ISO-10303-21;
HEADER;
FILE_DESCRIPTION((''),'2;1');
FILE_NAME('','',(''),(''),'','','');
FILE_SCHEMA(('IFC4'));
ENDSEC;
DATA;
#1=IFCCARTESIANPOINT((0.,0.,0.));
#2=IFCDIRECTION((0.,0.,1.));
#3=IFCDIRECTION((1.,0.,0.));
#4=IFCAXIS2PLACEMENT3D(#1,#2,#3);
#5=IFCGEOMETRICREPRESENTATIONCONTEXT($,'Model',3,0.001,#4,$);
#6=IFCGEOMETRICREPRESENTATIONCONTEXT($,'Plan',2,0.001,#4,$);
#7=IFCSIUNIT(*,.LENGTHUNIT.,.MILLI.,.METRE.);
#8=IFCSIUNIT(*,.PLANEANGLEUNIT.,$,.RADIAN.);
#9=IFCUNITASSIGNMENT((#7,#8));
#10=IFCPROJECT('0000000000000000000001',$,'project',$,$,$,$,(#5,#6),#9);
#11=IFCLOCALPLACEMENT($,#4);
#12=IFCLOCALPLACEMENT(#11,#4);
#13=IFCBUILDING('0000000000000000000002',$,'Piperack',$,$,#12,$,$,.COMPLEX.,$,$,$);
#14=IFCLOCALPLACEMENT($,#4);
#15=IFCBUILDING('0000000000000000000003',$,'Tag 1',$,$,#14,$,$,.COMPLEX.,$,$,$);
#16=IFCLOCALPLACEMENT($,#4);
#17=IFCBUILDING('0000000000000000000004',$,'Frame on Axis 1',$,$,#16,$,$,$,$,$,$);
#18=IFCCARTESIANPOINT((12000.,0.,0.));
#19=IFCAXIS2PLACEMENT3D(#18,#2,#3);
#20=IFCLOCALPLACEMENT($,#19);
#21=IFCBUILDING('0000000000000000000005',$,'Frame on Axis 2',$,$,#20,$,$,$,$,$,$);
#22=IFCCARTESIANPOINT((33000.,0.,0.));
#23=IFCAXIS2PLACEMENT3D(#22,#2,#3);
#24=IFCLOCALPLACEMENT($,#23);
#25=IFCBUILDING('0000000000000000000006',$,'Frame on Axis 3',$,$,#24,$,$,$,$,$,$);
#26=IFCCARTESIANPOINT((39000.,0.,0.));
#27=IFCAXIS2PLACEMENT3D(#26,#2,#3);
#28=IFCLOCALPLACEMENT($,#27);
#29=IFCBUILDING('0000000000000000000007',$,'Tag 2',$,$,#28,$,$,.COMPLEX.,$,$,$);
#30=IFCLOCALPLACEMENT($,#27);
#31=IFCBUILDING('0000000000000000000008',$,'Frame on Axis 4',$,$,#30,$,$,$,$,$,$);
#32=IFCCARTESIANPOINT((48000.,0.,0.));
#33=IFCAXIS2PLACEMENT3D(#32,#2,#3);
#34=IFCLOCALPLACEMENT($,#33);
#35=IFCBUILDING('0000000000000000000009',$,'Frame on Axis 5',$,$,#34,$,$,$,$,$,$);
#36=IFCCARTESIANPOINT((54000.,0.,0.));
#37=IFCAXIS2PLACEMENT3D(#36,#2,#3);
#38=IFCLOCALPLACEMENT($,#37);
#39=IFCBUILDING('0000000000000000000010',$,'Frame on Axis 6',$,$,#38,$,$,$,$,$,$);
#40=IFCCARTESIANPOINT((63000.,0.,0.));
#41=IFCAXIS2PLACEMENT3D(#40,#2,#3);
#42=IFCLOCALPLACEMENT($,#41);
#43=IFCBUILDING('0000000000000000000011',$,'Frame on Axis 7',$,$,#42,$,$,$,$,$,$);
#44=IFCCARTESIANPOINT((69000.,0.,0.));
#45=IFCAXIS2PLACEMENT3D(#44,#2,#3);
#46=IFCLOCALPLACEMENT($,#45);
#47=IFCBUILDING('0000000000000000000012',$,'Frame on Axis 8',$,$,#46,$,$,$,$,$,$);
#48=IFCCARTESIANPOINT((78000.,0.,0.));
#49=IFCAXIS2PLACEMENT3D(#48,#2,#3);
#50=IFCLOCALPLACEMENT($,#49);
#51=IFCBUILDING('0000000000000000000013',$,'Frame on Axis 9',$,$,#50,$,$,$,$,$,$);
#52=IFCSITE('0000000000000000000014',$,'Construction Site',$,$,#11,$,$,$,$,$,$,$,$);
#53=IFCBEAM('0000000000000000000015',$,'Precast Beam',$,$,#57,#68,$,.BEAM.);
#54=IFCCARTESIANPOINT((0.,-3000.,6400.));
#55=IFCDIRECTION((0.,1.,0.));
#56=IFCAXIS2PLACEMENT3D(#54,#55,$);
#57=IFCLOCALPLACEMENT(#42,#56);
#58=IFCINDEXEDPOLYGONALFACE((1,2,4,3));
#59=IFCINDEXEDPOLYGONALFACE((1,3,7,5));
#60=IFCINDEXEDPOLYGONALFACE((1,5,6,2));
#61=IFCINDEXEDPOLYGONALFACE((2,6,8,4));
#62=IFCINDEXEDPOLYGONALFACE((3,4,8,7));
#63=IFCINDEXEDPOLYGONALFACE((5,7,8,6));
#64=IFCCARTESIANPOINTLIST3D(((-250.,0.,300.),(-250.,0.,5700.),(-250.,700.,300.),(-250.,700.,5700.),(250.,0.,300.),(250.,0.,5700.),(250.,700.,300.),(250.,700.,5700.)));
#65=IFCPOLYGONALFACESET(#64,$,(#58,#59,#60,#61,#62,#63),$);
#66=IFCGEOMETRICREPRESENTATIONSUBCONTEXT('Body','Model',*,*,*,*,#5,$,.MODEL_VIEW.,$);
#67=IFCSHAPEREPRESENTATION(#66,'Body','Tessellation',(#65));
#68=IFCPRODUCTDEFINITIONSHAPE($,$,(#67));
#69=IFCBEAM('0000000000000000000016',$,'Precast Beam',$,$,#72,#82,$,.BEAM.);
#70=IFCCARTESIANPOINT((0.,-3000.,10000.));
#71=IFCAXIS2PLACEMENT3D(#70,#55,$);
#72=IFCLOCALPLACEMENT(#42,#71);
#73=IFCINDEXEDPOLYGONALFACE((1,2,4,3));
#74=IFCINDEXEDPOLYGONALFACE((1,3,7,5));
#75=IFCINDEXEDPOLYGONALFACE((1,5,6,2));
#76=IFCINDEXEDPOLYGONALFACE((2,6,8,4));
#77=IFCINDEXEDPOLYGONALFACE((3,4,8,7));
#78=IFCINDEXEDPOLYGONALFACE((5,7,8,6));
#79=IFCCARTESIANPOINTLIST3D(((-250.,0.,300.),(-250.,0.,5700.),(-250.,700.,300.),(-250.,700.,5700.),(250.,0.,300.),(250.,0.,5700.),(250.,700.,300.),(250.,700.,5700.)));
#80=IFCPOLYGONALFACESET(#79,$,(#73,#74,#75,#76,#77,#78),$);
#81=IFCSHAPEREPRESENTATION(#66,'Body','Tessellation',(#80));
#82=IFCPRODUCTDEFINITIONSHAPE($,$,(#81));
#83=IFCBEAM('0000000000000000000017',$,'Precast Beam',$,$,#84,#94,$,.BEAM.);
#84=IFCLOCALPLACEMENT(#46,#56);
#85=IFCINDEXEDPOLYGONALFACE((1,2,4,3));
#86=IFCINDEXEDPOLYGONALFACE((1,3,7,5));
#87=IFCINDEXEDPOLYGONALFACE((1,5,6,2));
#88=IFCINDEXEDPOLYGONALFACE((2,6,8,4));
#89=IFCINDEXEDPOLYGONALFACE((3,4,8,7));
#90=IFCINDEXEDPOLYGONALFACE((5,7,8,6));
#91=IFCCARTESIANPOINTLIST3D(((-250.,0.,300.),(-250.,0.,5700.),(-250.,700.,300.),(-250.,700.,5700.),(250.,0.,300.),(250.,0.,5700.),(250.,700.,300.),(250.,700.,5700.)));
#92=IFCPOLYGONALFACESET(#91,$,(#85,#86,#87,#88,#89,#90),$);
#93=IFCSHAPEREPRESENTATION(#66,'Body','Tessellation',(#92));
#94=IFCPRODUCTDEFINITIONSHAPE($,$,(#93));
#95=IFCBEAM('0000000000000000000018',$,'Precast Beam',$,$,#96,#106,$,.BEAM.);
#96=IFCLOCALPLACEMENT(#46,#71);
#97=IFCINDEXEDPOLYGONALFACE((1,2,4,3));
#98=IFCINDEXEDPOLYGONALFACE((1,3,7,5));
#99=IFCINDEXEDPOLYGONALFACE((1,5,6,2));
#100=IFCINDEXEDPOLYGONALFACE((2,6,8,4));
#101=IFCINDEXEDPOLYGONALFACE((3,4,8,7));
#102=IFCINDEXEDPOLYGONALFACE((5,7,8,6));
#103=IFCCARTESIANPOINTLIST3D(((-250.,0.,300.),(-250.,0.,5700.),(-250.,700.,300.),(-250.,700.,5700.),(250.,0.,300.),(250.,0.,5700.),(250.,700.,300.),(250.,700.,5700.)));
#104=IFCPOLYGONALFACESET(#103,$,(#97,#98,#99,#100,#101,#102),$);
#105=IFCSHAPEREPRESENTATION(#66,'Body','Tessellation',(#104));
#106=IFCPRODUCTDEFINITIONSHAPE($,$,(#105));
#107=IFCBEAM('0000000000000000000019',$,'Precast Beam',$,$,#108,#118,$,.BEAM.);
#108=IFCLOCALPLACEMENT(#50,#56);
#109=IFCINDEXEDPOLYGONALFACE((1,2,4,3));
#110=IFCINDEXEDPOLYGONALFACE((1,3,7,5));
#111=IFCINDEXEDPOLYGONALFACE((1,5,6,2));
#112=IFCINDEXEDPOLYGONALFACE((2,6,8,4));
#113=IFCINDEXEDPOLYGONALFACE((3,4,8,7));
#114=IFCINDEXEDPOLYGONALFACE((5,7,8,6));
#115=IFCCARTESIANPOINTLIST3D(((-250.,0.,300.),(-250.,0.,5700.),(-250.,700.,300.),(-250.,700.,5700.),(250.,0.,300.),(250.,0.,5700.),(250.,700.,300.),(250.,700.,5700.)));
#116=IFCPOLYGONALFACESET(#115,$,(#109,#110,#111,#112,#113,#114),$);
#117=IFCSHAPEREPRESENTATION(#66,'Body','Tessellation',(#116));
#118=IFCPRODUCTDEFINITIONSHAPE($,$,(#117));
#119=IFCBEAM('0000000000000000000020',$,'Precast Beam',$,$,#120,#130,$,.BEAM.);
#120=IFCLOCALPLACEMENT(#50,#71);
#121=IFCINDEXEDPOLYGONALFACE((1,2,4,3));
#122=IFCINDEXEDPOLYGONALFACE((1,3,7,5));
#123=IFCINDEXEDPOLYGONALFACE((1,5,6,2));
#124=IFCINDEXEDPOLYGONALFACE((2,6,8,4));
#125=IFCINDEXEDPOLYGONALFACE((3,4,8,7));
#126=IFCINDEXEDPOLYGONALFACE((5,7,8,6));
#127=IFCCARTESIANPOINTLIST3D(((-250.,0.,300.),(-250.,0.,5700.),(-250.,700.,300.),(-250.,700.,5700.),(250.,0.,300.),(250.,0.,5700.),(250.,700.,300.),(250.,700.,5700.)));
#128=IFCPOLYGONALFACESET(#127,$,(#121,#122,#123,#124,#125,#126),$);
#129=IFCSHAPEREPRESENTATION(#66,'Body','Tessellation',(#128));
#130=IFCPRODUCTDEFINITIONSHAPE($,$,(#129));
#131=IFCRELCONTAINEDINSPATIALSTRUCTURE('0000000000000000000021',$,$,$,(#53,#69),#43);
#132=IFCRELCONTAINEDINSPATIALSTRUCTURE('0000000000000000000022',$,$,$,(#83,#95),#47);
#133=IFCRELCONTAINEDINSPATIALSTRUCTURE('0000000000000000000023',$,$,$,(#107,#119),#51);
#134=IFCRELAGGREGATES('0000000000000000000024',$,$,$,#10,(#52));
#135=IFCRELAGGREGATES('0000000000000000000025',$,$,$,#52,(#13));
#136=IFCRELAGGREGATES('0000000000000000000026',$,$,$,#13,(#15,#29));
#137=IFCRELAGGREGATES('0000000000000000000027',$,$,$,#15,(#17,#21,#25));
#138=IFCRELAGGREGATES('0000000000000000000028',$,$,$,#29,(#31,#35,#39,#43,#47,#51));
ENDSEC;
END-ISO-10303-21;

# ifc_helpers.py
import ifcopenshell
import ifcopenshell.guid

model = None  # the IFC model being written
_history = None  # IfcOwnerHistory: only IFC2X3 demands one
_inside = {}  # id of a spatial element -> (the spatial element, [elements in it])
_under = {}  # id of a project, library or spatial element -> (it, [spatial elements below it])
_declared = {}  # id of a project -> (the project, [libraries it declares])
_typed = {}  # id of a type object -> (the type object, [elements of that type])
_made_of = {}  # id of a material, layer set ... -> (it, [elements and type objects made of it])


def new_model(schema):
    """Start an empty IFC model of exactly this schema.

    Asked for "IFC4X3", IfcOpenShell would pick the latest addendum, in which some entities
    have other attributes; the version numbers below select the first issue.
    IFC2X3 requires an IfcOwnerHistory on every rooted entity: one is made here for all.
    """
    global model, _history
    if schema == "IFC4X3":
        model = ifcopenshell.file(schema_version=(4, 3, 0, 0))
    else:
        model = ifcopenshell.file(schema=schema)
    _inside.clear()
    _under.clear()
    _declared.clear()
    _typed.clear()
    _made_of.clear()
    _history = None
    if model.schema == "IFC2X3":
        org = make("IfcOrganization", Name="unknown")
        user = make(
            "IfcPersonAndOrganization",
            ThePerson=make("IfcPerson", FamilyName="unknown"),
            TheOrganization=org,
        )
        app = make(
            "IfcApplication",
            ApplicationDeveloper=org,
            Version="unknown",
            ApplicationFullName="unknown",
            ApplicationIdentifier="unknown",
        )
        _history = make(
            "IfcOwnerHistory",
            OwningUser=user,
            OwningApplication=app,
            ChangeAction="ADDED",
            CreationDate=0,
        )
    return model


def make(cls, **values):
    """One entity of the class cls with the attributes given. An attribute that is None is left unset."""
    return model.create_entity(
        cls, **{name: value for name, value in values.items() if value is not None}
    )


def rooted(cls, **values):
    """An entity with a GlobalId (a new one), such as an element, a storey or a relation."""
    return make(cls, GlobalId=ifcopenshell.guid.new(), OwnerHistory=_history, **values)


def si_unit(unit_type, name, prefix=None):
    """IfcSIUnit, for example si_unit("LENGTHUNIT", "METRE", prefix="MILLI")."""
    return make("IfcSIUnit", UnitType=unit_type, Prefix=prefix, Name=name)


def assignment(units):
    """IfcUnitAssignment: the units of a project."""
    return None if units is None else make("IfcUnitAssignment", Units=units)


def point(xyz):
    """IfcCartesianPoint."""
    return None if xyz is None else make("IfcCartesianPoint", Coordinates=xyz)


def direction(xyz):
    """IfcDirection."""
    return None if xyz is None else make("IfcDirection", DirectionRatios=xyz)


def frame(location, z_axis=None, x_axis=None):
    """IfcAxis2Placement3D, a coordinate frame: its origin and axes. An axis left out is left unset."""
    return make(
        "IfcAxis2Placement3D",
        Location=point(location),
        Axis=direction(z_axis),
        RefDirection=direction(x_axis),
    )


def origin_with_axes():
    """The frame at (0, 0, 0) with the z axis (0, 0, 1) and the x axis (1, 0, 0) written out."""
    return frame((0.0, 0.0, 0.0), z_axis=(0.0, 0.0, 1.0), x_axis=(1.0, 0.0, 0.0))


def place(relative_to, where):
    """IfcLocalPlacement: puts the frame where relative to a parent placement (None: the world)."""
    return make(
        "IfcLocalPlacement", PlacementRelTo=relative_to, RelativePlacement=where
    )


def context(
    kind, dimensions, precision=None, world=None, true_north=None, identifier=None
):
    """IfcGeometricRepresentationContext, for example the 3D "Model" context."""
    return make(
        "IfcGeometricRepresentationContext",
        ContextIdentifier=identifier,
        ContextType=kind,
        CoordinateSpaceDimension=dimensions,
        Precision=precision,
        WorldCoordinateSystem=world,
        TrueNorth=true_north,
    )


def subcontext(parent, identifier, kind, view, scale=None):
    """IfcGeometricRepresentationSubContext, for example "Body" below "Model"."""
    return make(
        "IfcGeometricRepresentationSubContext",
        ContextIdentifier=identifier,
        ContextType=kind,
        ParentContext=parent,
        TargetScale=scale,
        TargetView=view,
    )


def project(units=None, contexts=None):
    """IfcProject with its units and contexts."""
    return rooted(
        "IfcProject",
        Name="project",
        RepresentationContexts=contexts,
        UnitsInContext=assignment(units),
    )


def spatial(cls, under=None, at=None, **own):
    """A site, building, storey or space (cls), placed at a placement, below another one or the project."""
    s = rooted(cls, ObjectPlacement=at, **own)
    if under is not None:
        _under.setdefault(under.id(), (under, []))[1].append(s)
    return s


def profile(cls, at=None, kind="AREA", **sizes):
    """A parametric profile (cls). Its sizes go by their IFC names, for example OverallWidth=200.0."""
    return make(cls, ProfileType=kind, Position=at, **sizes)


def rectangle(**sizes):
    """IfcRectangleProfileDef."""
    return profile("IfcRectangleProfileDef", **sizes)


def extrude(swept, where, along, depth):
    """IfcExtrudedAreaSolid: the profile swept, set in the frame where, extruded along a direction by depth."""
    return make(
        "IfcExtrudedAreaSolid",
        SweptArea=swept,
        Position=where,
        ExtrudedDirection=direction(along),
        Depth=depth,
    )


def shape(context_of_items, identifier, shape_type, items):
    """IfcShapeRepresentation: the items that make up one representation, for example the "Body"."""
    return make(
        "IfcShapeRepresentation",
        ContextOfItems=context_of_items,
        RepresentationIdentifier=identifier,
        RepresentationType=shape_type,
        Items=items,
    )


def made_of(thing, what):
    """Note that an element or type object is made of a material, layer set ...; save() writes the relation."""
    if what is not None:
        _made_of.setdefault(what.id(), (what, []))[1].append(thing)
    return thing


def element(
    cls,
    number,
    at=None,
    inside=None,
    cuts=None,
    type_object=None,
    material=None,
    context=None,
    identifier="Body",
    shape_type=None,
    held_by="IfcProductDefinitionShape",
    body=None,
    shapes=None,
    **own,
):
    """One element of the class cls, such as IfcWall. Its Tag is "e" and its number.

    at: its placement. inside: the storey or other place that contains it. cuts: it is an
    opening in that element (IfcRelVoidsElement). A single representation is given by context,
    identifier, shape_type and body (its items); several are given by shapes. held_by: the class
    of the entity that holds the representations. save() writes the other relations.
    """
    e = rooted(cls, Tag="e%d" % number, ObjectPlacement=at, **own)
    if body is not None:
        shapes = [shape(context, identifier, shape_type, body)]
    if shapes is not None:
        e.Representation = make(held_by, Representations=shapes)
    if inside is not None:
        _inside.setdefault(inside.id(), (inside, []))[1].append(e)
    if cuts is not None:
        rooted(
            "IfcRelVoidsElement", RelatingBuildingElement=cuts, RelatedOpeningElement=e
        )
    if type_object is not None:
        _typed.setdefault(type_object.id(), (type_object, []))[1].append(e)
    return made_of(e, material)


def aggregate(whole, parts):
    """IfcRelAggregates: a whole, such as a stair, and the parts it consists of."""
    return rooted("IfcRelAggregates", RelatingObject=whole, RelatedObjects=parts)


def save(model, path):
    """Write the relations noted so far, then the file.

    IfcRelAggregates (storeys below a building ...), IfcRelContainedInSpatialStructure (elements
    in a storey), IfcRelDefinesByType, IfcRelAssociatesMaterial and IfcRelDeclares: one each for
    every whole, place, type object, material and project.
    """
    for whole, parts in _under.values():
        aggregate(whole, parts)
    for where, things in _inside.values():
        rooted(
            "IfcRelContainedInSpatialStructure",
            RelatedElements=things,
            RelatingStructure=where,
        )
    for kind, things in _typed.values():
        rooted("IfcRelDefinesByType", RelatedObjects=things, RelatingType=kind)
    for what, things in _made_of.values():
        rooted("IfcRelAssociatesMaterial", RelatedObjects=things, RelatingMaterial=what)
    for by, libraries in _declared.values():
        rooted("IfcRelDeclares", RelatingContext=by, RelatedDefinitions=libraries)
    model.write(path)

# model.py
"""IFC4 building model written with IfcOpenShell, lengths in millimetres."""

from ifc_helpers import new_model, si_unit, frame, origin_with_axes, place, context, subcontext, project, spatial, rectangle, extrude, element, save


model = new_model("IFC4")

# Units and contexts
model_context = context("Model", 3, precision=0.001, world=origin_with_axes())
plan_context = context("Plan", 2, precision=0.001, world=origin_with_axes())
body_context = subcontext(model_context, "Body", "Model", "MODEL_VIEW")
ifc_project = project(units=[si_unit("LENGTHUNIT", "METRE", prefix="MILLI"), si_unit("PLANEANGLEUNIT", "RADIAN")], contexts=[model_context, plan_context])

# Site, buildings
site_placement = place(None, origin_with_axes())
site = spatial("IfcSite", under=ifc_project, at=site_placement, Name="Construction Site")
building_1_placement = place(site_placement, origin_with_axes())
building_1 = spatial("IfcBuilding", under=site, at=building_1_placement, Name="Piperack", CompositionType="COMPLEX")
building_2_placement = place(None, origin_with_axes())
building_2 = spatial("IfcBuilding", under=building_1, at=building_2_placement, Name="Tag 1", CompositionType="COMPLEX")
building_3_placement = place(None, origin_with_axes())
building_3 = spatial("IfcBuilding", under=building_2, at=building_3_placement, Name="Frame on Axis 1")

# Shared definitions
building_4_placement = place(None, frame((12000.0, 0.0, 0.0), z_axis=(0.0, 0.0, 1.0), x_axis=(1.0, 0.0, 0.0)))
building_4 = spatial("IfcBuilding", under=building_2, at=building_4_placement, Name="Frame on Axis 2")

# Shared definitions
building_5_placement = place(None, frame((33000.0, 0.0, 0.0), z_axis=(0.0, 0.0, 1.0), x_axis=(1.0, 0.0, 0.0)))
building_5 = spatial("IfcBuilding", under=building_2, at=building_5_placement, Name="Frame on Axis 3")

# Shared definitions
building_6_placement = place(None, frame((39000.0, 0.0, 0.0), z_axis=(0.0, 0.0, 1.0), x_axis=(1.0, 0.0, 0.0)))
building_6 = spatial("IfcBuilding", under=building_1, at=building_6_placement, Name="Tag 2", CompositionType="COMPLEX")
building_7_placement = place(None, frame((39000.0, 0.0, 0.0), z_axis=(0.0, 0.0, 1.0), x_axis=(1.0, 0.0, 0.0)))
building_7 = spatial("IfcBuilding", under=building_6, at=building_7_placement, Name="Frame on Axis 4")

# Shared definitions
building_8_placement = place(None, frame((48000.0, 0.0, 0.0), z_axis=(0.0, 0.0, 1.0), x_axis=(1.0, 0.0, 0.0)))
building_8 = spatial("IfcBuilding", under=building_6, at=building_8_placement, Name="Frame on Axis 5")

# Shared definitions
building_9_placement = place(None, frame((54000.0, 0.0, 0.0), z_axis=(0.0, 0.0, 1.0), x_axis=(1.0, 0.0, 0.0)))
building_9 = spatial("IfcBuilding", under=building_6, at=building_9_placement, Name="Frame on Axis 6")

# Shared definitions
building_10_placement = place(None, frame((63000.0, 0.0, 0.0), z_axis=(0.0, 0.0, 1.0), x_axis=(1.0, 0.0, 0.0)))
building_10 = spatial("IfcBuilding", under=building_6, at=building_10_placement, Name="Frame on Axis 7")

# Shared definitions
building_11_placement = place(None, frame((69000.0, 0.0, 0.0), z_axis=(0.0, 0.0, 1.0), x_axis=(1.0, 0.0, 0.0)))
building_11 = spatial("IfcBuilding", under=building_6, at=building_11_placement, Name="Frame on Axis 8")

# Shared definitions
building_12_placement = place(None, frame((78000.0, 0.0, 0.0), z_axis=(0.0, 0.0, 1.0), x_axis=(1.0, 0.0, 0.0)))
building_12 = spatial("IfcBuilding", under=building_6, at=building_12_placement, Name="Frame on Axis 9")

# Beams
for number, where, z_axis, name in (
    (1, (0.0, -3000.0, 6400.0), (0.0, 1.0, 0.0), "Precast Beam"),
    (2, (0.0, -3000.0, 10000.0), (0.0, 1.0, 0.0), "Precast Beam"),
):
    element("IfcBeam", number, at=place(building_10_placement, frame(where, z_axis=z_axis)), inside=building_10, Name=name, PredefinedType="BEAM", context=body_context, shape_type="SweptSolid", body=[
        extrude(rectangle(XDim=500.0, YDim=700.0), frame((0.0, 350.0, 300.0)), (0.0, 0.0, 1.0), 5400.0),
    ])
for number, where, z_axis, name in (
    (3, (0.0, -3000.0, 6400.0), (0.0, 1.0, 0.0), "Precast Beam"),
    (4, (0.0, -3000.0, 10000.0), (0.0, 1.0, 0.0), "Precast Beam"),
):
    element("IfcBeam", number, at=place(building_11_placement, frame(where, z_axis=z_axis)), inside=building_11, Name=name, PredefinedType="BEAM", context=body_context, shape_type="SweptSolid", body=[
        extrude(rectangle(XDim=500.0, YDim=700.0), frame((0.0, 350.0, 300.0)), (0.0, 0.0, 1.0), 5400.0),
    ])
for number, where, z_axis, name in (
    (5, (0.0, -3000.0, 6400.0), (0.0, 1.0, 0.0), "Precast Beam"),
    (6, (0.0, -3000.0, 10000.0), (0.0, 1.0, 0.0), "Precast Beam"),
):
    element("IfcBeam", number, at=place(building_12_placement, frame(where, z_axis=z_axis)), inside=building_12, Name=name, PredefinedType="BEAM", context=body_context, shape_type="SweptSolid", body=[
        extrude(rectangle(XDim=500.0, YDim=700.0), frame((0.0, 350.0, 300.0)), (0.0, 0.0, 1.0), 5400.0),
    ])

save(model, "model.ifc")
